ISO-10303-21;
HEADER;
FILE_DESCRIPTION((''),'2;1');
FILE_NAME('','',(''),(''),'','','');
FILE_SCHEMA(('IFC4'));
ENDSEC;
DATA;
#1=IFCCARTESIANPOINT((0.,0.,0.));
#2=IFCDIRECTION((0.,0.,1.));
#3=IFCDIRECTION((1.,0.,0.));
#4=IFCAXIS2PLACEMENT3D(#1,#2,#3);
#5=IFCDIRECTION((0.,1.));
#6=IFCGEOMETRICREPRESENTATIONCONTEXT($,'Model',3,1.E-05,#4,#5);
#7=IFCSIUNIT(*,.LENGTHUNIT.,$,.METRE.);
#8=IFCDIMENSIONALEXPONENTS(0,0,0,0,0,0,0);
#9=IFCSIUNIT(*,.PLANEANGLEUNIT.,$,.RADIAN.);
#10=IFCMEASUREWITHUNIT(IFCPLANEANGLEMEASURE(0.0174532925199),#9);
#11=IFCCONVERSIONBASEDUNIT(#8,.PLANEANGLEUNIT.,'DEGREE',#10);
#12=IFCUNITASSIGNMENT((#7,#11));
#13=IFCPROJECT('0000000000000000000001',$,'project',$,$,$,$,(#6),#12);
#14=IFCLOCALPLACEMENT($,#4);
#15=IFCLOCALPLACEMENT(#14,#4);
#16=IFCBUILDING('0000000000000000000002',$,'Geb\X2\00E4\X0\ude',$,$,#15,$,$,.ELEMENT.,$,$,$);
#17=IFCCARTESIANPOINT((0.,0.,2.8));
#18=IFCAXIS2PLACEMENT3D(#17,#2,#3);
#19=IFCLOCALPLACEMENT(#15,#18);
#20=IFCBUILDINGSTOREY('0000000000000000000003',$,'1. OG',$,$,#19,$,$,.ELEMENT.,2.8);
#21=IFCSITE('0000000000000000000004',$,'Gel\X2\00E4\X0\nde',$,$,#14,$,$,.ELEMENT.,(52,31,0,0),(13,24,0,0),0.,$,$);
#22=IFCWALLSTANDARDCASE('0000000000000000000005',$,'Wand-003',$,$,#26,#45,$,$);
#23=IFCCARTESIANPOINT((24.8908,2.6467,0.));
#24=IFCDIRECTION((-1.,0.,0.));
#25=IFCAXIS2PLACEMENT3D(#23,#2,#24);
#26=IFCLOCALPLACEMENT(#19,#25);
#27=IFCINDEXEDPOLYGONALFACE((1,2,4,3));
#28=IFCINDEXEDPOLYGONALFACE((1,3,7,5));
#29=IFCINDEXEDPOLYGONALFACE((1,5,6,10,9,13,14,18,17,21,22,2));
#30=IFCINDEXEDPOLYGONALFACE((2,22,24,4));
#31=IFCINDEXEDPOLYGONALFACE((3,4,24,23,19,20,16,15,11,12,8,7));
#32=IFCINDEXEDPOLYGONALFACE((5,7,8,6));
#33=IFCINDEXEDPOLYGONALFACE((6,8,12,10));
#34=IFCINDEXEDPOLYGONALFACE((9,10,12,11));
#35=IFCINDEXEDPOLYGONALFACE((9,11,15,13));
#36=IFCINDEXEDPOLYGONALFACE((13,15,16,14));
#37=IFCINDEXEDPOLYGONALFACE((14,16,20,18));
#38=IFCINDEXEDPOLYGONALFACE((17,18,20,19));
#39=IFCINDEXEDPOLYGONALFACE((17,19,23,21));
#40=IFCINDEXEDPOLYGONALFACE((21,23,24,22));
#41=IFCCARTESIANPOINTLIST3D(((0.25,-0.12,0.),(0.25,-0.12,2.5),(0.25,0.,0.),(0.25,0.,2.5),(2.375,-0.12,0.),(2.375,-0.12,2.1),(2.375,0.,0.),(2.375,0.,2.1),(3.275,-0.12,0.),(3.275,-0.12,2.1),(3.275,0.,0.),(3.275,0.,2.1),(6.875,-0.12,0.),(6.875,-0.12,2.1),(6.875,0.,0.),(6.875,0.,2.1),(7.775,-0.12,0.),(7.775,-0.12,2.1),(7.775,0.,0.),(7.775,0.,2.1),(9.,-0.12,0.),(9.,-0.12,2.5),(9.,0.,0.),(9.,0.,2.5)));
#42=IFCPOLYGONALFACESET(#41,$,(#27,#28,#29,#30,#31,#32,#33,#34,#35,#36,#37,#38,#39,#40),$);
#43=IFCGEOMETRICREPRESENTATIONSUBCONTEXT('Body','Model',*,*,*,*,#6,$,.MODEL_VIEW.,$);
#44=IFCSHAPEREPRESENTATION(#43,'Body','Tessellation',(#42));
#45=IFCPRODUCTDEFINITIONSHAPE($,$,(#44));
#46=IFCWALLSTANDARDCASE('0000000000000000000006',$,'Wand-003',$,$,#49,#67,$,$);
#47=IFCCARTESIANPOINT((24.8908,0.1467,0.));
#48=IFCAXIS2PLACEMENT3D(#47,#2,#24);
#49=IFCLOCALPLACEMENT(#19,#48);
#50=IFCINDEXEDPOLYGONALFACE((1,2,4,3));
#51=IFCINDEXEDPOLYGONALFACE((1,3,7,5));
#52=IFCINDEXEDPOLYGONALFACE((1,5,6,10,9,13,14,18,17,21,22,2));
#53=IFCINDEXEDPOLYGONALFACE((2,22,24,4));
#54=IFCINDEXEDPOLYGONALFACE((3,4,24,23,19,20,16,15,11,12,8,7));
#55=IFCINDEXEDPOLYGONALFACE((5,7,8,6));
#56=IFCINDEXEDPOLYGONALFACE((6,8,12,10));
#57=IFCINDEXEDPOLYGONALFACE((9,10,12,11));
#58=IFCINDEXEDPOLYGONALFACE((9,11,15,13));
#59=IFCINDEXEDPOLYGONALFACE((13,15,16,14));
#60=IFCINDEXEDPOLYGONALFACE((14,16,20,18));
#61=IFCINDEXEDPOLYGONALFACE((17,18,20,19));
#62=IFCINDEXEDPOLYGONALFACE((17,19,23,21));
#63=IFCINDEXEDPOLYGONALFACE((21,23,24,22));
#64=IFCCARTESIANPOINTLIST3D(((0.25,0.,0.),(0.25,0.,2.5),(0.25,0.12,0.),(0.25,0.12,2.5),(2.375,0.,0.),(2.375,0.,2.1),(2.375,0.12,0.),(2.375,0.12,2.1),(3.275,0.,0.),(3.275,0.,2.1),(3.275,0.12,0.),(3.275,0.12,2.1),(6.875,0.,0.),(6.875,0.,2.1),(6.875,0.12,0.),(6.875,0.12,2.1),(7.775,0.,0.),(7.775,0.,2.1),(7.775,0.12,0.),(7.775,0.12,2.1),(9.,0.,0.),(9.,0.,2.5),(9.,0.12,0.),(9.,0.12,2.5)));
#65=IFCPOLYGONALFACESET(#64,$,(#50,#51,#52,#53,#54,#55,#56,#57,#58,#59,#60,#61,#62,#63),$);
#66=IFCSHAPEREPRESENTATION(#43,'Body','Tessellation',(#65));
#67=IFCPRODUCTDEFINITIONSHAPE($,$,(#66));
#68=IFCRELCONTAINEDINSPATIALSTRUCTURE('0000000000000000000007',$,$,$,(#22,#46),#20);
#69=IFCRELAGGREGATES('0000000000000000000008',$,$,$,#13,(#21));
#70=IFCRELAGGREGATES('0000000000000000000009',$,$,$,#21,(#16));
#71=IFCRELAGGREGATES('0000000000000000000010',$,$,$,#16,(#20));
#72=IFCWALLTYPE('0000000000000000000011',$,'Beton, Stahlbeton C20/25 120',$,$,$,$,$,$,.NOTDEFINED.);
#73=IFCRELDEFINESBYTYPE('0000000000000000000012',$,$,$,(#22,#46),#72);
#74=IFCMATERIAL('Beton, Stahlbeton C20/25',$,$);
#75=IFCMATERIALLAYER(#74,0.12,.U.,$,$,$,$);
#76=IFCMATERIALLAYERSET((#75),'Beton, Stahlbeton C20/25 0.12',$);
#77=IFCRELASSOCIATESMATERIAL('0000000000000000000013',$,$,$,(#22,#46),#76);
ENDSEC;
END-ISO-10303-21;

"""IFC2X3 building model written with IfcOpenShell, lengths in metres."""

from ifc_helpers import new_model, entity, si_unit, converted_unit, direction, frame, origin_with_axes, origin_2d_with_axis, place, context, subcontext, project, spatial, polyline, rectangle, outline, extrude, material, layer, layer_set, layer_usage, type_object, element, save


model = new_model("IFC2X3")

# Units and contexts
model_context = context("Model", 3, precision=1e-05, world=origin_with_axes(), true_north=direction((0.0, 1.0)))
body_context = subcontext(model_context, "Body", "Model", "MODEL_VIEW")
ifc_project = project(units=[si_unit("LENGTHUNIT", "METRE"), converted_unit("PLANEANGLEUNIT", "DEGREE", entity("IfcPlaneAngleMeasure", 0.0174532925199), si_unit("PLANEANGLEUNIT", "RADIAN"), dimensions=[0, 0, 0, 0, 0, 0, 0])], contexts=[model_context])

# Site, building, storey
site_placement = place(None, origin_with_axes())
site = spatial("IfcSite", under=ifc_project, at=site_placement, Name="Gelände", CompositionType="ELEMENT", RefLatitude=(52, 31, 0, 0), RefLongitude=(13, 24, 0, 0), RefElevation=0.0)
building_placement = place(site_placement, origin_with_axes())
building = spatial("IfcBuilding", under=site, at=building_placement, Name="Gebäude", CompositionType="ELEMENT")
storey_placement = place(building_placement, frame((0.0, 0.0, 2.8), z_axis=(0.0, 0.0, 1.0), x_axis=(1.0, 0.0, 0.0)))
storey = spatial("IfcBuildingStorey", under=building, at=storey_placement, Name="1. OG", CompositionType="ELEMENT", Elevation=2.8)

# Shared definitions
ifc_material_1 = material(Name="Beton, Stahlbeton C20/25")

# Walls, openings
ifc_layer_1 = layer(ifc_material_1, 0.12, ventilated="UNKNOWN")
ifc_layer_set_1 = layer_set([ifc_layer_1], Name="Beton, Stahlbeton C20/25 0.12")
ifc_layer_usage_1 = layer_usage(ifc_layer_set_1, "AXIS2", "NEGATIVE", 0.0)
wall_type_1 = type_object("IfcWallType", Name="Beton, Stahlbeton C20/25 120", PredefinedType="NOTDEFINED")
wall_1_placement = place(storey_placement, frame((24.8908, 2.6467, 0.0), z_axis=(0.0, 0.0, 1.0), x_axis=(-1.0, 0.0, 0.0)))
wall_1 = element("IfcWallStandardCase", 1, at=wall_1_placement, inside=storey, type_object=wall_type_1, material=ifc_layer_usage_1, Name="Wand-003", context=body_context, shape_type="SweptSolid", body=[
    extrude(outline(polyline([(0.25, -0.12), (9.0, -0.12), (9.0, 0.0), (0.25, 0.0), (0.25, -0.12)])), origin_with_axes(), (0.0, 0.0, 1.0), 2.5),
])
opening_1_placement = place(wall_1_placement, frame((7.325, 0.0, 0.0), z_axis=(0.0, 0.0, 1.0), x_axis=(1.0, 0.0, 0.0)))
element("IfcOpeningElement", 2, at=opening_1_placement, cuts=wall_1, context=body_context, shape_type="SweptSolid", body=[
    extrude(rectangle(XDim=0.9, YDim=2.1, at=origin_2d_with_axis()), frame((0.0, -0.24, 1.05), z_axis=(0.0, 1.0, 0.0), x_axis=(-1.0, 0.0, 0.0)), (0.0, 0.0, 1.0), 0.36),
])
opening_2_placement = place(wall_1_placement, frame((2.825, 0.0, 0.0), z_axis=(0.0, 0.0, 1.0), x_axis=(1.0, 0.0, 0.0)))
element("IfcOpeningElement", 3, at=opening_2_placement, cuts=wall_1, context=body_context, shape_type="SweptSolid", body=[
    extrude(rectangle(XDim=0.9, YDim=2.1, at=origin_2d_with_axis()), frame((0.0, -0.24, 1.05), z_axis=(0.0, 1.0, 0.0), x_axis=(-1.0, 0.0, 0.0)), (0.0, 0.0, 1.0), 0.36),
])
ifc_layer_usage_2 = layer_usage(ifc_layer_set_1, "AXIS2", "POSITIVE", 0.0)
wall_2_placement = place(storey_placement, frame((24.8908, 0.1467, 0.0), z_axis=(0.0, 0.0, 1.0), x_axis=(-1.0, 0.0, 0.0)))
wall_2 = element("IfcWallStandardCase", 4, at=wall_2_placement, inside=storey, type_object=wall_type_1, material=ifc_layer_usage_2, Name="Wand-003", context=body_context, shape_type="SweptSolid", body=[
    extrude(outline(polyline([(0.25, 0.0), (9.0, 0.0), (9.0, 0.12), (0.25, 0.12), (0.25, 0.0)])), origin_with_axes(), (0.0, 0.0, 1.0), 2.5),
])
opening_3_placement = place(wall_2_placement, frame((7.325, 0.0, 0.0), z_axis=(0.0, 0.0, 1.0), x_axis=(1.0, 0.0, 0.0)))
element("IfcOpeningElement", 5, at=opening_3_placement, cuts=wall_2, context=body_context, shape_type="SweptSolid", body=[
    extrude(rectangle(XDim=0.9, YDim=2.1, at=origin_2d_with_axis()), frame((0.0, 0.24, 1.05), z_axis=(0.0, 1.0, 0.0), x_axis=(-1.0, 0.0, 0.0)), (0.0, 0.0, -1.0), 0.36),
])
opening_4_placement = place(wall_2_placement, frame((2.825, 0.0, 0.0), z_axis=(0.0, 0.0, 1.0), x_axis=(1.0, 0.0, 0.0)))
element("IfcOpeningElement", 6, at=opening_4_placement, cuts=wall_2, context=body_context, shape_type="SweptSolid", body=[
    extrude(rectangle(XDim=0.9, YDim=2.1, at=origin_2d_with_axis()), frame((0.0, 0.24, 1.05), z_axis=(0.0, 1.0, 0.0), x_axis=(-1.0, 0.0, 0.0)), (0.0, 0.0, -1.0), 0.36),
])

save(model, "model.ifc")
